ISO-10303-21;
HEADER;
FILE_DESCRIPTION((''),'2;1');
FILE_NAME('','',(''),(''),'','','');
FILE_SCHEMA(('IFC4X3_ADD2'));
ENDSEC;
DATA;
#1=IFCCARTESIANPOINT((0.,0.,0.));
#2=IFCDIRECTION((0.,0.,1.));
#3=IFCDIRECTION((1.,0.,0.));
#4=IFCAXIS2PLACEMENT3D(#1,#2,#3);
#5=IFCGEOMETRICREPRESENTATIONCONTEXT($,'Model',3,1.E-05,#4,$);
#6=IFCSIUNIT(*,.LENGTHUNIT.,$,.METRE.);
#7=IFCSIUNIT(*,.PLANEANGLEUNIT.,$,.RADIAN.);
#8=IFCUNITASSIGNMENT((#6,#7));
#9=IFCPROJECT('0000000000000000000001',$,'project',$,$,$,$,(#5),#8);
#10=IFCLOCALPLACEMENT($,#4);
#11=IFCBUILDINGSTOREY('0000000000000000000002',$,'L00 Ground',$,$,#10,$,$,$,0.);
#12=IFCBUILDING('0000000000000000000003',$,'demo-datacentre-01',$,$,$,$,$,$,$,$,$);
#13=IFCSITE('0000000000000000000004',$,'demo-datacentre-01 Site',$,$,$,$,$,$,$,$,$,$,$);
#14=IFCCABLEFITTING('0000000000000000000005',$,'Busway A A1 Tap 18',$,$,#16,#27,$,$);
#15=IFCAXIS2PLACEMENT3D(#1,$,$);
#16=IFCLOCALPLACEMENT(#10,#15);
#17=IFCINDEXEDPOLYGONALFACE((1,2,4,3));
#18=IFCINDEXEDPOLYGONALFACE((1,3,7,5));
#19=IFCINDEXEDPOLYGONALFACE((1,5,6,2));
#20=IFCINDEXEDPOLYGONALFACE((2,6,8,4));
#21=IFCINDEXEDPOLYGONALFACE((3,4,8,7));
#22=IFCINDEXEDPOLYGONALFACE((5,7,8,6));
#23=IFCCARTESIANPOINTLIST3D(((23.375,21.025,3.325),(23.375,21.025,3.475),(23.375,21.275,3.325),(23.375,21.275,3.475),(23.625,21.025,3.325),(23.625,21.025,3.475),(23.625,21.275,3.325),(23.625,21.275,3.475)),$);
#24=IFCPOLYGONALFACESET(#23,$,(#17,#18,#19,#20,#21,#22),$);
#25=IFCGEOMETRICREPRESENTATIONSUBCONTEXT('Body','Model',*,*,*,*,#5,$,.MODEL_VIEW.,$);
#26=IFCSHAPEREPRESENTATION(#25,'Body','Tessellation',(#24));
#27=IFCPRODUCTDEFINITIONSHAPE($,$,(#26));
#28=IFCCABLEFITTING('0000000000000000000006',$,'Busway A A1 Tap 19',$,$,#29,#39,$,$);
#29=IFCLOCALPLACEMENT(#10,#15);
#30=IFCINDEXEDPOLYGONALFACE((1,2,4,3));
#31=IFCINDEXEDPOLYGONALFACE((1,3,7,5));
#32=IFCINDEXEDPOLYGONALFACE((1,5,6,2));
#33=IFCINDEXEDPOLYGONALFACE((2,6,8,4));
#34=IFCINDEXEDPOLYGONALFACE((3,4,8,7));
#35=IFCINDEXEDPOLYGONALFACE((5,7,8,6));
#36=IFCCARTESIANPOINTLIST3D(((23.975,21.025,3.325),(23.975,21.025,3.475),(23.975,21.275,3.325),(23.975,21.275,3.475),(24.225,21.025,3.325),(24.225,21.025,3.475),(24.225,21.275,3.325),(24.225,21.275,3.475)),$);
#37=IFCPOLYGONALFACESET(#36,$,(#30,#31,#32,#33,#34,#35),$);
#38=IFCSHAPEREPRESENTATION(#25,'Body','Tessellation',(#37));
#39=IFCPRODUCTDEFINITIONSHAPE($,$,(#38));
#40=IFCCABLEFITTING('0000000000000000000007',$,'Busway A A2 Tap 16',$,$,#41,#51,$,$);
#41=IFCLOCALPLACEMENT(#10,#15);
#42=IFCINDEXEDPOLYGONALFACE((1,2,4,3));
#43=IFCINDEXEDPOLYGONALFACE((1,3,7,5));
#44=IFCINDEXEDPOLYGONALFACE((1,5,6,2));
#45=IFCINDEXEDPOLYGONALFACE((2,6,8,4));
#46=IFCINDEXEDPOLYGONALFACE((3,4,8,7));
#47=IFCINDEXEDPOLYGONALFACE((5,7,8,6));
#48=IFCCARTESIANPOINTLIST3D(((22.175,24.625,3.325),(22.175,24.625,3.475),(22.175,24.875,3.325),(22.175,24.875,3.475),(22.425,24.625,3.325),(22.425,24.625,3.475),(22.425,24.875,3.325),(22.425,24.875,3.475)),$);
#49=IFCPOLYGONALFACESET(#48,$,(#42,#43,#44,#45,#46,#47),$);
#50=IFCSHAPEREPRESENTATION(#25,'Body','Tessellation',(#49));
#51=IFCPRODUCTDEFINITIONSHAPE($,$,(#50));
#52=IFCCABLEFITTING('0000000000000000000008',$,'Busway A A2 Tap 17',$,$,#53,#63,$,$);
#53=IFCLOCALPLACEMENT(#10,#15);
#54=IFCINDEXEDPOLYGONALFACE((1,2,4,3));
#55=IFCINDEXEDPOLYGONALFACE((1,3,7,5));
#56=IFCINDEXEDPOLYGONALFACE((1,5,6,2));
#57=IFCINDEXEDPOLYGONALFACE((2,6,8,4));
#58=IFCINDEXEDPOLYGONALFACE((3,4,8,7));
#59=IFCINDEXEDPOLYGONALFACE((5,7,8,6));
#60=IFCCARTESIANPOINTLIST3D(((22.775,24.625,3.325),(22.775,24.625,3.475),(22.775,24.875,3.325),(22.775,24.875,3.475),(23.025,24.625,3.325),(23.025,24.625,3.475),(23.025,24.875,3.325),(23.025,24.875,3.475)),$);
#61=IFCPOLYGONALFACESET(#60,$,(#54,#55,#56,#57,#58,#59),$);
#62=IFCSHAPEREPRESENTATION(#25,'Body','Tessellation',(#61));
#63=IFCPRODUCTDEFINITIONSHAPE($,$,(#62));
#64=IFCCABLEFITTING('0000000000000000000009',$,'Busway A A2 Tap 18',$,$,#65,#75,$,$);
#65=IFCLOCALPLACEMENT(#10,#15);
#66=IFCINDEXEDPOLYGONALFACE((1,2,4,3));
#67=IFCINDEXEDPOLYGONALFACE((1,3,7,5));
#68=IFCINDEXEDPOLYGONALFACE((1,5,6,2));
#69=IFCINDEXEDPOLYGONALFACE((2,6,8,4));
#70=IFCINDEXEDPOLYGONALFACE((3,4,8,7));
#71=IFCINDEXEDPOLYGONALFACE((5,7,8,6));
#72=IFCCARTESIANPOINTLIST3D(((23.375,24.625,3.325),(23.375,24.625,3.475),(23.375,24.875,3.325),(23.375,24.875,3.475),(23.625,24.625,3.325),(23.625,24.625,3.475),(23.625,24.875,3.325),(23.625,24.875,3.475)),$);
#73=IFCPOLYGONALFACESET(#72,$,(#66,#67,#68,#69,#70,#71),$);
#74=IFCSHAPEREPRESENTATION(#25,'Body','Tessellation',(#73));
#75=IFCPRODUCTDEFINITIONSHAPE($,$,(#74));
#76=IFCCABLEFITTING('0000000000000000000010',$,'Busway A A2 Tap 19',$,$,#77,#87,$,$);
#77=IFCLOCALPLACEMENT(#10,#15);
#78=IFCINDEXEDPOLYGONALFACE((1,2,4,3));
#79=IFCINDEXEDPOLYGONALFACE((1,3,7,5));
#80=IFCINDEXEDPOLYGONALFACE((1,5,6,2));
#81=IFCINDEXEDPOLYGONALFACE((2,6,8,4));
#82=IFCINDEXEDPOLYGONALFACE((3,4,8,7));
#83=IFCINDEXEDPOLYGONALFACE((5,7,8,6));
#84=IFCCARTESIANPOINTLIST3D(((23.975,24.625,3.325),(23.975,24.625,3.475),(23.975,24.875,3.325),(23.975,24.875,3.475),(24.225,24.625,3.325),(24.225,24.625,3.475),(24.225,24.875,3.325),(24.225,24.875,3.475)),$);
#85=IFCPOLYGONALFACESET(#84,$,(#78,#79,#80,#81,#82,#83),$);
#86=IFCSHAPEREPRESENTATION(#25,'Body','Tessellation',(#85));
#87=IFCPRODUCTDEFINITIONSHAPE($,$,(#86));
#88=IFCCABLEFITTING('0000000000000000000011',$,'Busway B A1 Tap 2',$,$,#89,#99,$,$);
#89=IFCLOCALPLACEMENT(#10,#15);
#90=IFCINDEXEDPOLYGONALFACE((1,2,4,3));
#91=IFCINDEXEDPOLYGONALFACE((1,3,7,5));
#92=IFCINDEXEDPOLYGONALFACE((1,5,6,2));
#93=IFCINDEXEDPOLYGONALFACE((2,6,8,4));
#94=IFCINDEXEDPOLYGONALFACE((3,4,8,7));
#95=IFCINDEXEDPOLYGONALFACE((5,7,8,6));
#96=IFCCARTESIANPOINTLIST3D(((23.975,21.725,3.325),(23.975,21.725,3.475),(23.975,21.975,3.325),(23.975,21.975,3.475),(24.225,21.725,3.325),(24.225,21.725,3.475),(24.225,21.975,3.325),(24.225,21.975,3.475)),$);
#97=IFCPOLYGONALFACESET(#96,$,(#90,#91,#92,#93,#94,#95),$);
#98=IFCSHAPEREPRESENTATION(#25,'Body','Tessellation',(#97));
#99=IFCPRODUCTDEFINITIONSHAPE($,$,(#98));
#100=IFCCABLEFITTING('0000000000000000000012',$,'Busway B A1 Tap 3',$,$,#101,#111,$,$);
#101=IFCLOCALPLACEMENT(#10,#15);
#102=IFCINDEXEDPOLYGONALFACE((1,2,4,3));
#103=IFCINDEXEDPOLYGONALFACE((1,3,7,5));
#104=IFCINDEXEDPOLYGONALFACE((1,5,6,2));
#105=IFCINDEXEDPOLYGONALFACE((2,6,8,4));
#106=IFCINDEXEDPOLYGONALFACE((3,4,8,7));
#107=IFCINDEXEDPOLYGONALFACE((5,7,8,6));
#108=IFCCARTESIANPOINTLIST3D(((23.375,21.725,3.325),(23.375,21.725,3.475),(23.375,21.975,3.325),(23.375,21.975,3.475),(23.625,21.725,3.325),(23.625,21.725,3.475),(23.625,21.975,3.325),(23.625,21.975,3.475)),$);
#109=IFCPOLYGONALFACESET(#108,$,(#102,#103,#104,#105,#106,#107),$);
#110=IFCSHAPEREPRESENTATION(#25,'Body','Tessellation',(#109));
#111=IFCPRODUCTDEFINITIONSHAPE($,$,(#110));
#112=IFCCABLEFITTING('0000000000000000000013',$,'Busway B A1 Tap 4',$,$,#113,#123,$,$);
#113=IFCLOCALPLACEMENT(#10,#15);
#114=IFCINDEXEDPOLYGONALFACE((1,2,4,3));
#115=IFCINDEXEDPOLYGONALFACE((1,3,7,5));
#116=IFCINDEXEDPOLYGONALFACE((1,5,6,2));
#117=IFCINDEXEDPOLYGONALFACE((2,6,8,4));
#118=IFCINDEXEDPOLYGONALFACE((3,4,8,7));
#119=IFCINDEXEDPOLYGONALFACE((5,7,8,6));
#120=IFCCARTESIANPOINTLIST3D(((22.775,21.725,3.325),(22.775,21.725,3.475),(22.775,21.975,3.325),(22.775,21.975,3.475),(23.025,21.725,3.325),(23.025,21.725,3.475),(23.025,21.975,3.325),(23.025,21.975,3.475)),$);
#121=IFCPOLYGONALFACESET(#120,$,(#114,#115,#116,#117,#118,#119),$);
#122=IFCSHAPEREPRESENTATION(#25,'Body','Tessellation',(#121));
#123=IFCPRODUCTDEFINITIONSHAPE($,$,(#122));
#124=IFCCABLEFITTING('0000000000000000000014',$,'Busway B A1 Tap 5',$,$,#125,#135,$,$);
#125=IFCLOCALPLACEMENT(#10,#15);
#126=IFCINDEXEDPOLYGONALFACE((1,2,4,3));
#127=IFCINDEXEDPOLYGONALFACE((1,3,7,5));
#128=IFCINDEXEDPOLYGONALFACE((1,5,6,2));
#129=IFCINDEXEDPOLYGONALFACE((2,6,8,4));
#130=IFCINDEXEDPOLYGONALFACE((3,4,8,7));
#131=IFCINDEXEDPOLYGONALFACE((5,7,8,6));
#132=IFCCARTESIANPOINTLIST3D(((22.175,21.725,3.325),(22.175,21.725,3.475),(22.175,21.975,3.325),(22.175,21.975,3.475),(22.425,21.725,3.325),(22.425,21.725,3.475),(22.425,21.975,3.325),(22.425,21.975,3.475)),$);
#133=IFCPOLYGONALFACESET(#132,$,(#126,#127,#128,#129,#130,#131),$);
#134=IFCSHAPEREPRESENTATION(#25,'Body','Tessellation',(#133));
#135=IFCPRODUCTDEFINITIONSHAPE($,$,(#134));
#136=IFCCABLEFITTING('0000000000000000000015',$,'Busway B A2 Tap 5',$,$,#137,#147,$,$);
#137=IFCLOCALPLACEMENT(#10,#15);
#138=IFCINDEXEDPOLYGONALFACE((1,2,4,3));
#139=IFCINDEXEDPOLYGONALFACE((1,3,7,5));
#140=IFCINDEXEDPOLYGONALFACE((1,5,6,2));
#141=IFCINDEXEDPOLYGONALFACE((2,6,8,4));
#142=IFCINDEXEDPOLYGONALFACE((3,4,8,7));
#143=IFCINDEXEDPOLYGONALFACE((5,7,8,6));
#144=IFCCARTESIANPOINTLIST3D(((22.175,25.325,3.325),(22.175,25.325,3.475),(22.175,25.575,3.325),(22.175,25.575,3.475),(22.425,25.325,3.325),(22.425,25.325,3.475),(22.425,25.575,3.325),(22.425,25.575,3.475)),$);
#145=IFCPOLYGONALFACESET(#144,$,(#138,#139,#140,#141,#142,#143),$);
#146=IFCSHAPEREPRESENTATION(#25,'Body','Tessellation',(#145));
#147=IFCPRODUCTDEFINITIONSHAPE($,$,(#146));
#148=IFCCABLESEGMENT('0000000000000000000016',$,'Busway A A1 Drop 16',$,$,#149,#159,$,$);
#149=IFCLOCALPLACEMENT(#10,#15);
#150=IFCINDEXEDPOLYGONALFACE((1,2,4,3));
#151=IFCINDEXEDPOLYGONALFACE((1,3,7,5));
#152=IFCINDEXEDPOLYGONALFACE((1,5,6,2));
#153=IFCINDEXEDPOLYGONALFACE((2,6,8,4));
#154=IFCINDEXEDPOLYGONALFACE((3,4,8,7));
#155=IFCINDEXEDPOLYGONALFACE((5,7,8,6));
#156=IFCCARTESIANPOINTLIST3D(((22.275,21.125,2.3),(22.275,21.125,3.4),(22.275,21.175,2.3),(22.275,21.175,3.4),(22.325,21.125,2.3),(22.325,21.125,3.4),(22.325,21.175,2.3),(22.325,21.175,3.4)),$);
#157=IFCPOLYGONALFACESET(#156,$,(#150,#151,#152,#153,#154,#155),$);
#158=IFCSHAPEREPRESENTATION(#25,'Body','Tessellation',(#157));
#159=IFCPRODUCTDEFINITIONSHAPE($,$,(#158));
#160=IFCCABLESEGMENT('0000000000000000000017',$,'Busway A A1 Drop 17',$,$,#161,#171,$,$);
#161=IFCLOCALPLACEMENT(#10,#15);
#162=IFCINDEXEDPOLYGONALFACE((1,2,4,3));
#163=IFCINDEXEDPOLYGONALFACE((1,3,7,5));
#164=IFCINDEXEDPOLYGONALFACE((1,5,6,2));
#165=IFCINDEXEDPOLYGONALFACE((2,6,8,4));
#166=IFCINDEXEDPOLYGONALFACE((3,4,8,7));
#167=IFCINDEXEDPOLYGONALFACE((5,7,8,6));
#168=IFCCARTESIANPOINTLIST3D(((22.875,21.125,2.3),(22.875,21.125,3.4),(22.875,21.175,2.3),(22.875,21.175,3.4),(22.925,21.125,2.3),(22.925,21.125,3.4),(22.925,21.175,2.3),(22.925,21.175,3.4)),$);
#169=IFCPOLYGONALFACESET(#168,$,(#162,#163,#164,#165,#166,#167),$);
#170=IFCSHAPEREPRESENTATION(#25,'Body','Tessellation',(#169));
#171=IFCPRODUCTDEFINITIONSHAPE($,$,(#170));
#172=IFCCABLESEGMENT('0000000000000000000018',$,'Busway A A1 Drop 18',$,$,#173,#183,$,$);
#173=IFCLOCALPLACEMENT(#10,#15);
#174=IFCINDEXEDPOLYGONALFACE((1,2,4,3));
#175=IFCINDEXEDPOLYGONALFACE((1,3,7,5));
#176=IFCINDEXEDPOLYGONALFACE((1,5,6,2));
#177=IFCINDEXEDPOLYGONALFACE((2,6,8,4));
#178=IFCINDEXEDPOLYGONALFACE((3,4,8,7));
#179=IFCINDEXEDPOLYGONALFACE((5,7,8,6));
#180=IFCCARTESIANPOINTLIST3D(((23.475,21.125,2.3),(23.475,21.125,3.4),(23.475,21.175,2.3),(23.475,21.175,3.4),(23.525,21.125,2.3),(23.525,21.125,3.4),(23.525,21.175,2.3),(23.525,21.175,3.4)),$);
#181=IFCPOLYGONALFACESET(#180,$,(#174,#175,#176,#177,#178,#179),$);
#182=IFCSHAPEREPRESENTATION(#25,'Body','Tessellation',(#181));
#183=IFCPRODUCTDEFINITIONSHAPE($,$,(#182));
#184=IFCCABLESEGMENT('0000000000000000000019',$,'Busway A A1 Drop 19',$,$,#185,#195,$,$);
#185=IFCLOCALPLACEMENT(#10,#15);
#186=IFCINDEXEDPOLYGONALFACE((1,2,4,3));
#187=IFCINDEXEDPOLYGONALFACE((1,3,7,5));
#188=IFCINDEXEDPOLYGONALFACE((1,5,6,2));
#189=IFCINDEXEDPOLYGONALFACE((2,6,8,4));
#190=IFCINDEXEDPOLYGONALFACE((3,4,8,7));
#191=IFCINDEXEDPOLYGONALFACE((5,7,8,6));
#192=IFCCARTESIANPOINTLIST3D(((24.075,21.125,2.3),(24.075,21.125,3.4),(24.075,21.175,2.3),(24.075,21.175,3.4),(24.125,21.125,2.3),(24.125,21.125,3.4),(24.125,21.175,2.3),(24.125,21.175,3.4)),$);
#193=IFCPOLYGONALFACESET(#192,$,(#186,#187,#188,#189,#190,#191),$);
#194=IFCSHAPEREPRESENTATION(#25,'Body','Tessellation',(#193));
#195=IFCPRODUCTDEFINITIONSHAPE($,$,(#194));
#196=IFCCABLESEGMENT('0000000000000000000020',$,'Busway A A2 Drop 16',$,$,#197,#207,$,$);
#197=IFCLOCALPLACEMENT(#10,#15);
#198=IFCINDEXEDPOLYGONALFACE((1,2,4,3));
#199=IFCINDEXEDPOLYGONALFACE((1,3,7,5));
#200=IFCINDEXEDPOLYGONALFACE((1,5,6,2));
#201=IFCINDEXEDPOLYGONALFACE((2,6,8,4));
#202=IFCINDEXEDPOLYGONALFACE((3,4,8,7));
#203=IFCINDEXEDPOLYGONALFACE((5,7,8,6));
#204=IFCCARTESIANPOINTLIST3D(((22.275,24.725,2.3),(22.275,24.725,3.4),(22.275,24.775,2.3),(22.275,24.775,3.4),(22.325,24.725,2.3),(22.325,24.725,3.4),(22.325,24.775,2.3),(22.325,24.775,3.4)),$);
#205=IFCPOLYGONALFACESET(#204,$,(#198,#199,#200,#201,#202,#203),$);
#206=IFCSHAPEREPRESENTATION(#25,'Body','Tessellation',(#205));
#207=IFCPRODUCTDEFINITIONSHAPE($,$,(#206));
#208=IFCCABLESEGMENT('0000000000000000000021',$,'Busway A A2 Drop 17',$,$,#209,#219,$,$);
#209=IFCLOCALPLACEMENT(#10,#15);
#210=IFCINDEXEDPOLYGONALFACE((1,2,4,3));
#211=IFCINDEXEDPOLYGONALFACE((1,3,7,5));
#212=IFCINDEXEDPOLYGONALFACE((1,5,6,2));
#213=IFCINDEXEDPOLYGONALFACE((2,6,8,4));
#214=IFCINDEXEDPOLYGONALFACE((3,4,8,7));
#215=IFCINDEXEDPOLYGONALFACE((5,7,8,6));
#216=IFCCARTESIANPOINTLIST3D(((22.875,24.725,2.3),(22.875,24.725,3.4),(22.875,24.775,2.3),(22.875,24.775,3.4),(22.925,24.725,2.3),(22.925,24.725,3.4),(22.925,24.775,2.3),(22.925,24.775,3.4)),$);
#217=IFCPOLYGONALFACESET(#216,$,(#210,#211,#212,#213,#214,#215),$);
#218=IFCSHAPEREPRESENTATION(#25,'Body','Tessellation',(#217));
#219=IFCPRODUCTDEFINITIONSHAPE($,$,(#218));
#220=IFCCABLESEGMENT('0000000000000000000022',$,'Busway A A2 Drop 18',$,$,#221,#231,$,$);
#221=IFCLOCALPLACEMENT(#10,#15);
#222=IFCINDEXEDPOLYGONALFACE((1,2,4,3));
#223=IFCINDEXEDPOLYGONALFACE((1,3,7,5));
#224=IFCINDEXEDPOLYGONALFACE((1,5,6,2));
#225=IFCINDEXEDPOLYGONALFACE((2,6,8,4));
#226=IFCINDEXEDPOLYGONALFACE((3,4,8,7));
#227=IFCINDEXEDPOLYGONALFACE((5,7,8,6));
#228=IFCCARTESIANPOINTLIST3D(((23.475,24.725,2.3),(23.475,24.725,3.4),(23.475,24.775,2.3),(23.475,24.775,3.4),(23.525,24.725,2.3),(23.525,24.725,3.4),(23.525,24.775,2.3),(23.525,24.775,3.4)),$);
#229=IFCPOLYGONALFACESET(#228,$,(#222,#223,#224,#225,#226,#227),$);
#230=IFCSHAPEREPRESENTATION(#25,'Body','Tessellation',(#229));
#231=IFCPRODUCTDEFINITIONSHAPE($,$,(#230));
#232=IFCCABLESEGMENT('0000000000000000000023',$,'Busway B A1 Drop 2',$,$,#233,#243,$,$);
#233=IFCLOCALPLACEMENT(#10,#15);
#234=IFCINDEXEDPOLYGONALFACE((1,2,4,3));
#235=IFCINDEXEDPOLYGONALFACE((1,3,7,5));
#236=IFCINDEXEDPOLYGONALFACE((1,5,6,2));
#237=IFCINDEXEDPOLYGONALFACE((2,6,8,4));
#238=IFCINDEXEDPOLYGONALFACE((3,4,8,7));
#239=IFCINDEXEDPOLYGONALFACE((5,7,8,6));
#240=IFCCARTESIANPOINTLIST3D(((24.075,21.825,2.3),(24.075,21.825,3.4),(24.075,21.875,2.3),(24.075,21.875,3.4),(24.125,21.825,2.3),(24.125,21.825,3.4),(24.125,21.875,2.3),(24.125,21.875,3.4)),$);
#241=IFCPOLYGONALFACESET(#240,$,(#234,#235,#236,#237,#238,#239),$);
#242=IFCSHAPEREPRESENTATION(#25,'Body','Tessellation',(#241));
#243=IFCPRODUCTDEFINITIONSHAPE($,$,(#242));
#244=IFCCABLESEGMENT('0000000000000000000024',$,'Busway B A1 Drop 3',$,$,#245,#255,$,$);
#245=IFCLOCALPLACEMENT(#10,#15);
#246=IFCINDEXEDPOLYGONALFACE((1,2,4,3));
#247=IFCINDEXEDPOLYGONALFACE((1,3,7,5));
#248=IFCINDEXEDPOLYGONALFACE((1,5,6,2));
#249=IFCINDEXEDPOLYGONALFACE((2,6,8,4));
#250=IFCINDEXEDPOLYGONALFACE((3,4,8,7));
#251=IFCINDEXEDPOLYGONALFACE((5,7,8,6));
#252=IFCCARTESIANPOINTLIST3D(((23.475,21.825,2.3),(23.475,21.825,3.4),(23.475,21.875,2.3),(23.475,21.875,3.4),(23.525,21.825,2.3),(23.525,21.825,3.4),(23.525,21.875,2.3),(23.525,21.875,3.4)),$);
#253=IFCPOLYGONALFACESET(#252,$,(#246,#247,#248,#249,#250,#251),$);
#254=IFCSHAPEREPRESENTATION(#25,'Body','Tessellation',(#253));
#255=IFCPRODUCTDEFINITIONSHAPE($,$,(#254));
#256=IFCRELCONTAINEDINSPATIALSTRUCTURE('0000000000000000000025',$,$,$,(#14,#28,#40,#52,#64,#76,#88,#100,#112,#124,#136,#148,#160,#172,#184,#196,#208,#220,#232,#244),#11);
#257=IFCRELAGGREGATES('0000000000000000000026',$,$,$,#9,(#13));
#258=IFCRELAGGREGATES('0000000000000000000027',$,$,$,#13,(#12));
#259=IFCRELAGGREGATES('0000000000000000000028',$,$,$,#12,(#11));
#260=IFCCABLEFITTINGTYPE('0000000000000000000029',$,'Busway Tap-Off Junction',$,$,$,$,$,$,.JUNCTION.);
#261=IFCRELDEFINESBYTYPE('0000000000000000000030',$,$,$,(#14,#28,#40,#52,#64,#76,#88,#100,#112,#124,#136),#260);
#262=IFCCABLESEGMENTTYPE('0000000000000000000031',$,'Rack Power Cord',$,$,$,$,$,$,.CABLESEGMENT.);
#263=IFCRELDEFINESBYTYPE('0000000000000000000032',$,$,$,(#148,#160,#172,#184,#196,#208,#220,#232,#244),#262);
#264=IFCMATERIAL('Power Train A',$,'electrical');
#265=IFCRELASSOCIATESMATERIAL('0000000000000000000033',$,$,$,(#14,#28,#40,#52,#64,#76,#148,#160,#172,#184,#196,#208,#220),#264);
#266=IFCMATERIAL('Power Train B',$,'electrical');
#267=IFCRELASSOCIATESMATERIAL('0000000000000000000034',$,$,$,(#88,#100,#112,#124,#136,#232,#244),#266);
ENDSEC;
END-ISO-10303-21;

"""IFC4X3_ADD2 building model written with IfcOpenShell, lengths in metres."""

from ifc_helpers import new_model, si_unit, frame, origin_with_axes, place, context, subcontext, project, spatial, rectangle, extrude, material, type_object, element, save


model = new_model("IFC4X3_ADD2")

# Units and contexts
model_context = context("Model", 3, precision=1e-05, world=origin_with_axes())
body_context = subcontext(model_context, "Body", "Model", "MODEL_VIEW")
ifc_project = project(units=[si_unit("LENGTHUNIT", "METRE"), si_unit("PLANEANGLEUNIT", "RADIAN")], contexts=[model_context])

# Site, building, storey
site = spatial("IfcSite", under=ifc_project, Name="demo-datacentre-01 Site")
building = spatial("IfcBuilding", under=site, Name="demo-datacentre-01")
storey_placement = place(None, origin_with_axes())
storey = spatial("IfcBuildingStorey", under=building, at=storey_placement, Name="L00 Ground", Elevation=0.0)

# Shared definitions
ifc_material_1 = material(Name="Power Train B", Category="electrical")

# Shared definitions
ifc_material_2 = material(Name="Power Train A", Category="electrical")

# Cable fittings
cable_fitting_type_1 = type_object("IfcCableFittingType", Name="Busway Tap-Off Junction", PredefinedType="JUNCTION")
for number, where, z_axis, x_axis, name in (
    (1, (23.5, 21.15, 3.325), (0.0, 0.0, 1.0), (1.0, 0.0, 0.0), "Busway A A1 Tap 18"),
    (2, (24.1, 21.15, 3.325), (0.0, 0.0, 1.0), (1.0, 0.0, 0.0), "Busway A A1 Tap 19"),
    (3, (22.3, 24.75, 3.325), (0.0, 0.0, 1.0), (1.0, 0.0, 0.0), "Busway A A2 Tap 16"),
    (4, (22.9, 24.75, 3.325), (0.0, 0.0, 1.0), (1.0, 0.0, 0.0), "Busway A A2 Tap 17"),
    (5, (23.5, 24.75, 3.325), (0.0, 0.0, 1.0), (1.0, 0.0, 0.0), "Busway A A2 Tap 18"),
    (6, (24.1, 24.75, 3.325), (0.0, 0.0, 1.0), (1.0, 0.0, 0.0), "Busway A A2 Tap 19"),
):
    element("IfcCableFitting", number, at=place(storey_placement, frame(where, z_axis=z_axis, x_axis=x_axis)), inside=storey, type_object=cable_fitting_type_1, material=ifc_material_2, Name=name, context=body_context, shape_type="SweptSolid", body=[
        extrude(rectangle(XDim=0.25, YDim=0.25), origin_with_axes(), (0.0, 0.0, 1.0), 0.15),
    ])
for number, where, z_axis, x_axis, name in (
    (7, (24.1, 21.85, 3.325), (0.0, 0.0, 1.0), (1.0, 0.0, 0.0), "Busway B A1 Tap 2"),
    (8, (23.5, 21.85, 3.325), (0.0, 0.0, 1.0), (1.0, 0.0, 0.0), "Busway B A1 Tap 3"),
    (9, (22.9, 21.85, 3.325), (0.0, 0.0, 1.0), (1.0, 0.0, 0.0), "Busway B A1 Tap 4"),
    (10, (22.3, 21.85, 3.325), (0.0, 0.0, 1.0), (1.0, 0.0, 0.0), "Busway B A1 Tap 5"),
    (11, (22.3, 25.45, 3.325), (0.0, 0.0, 1.0), (1.0, 0.0, 0.0), "Busway B A2 Tap 5"),
):
    element("IfcCableFitting", number, at=place(storey_placement, frame(where, z_axis=z_axis, x_axis=x_axis)), inside=storey, type_object=cable_fitting_type_1, material=ifc_material_1, Name=name, context=body_context, shape_type="SweptSolid", body=[
        extrude(rectangle(XDim=0.25, YDim=0.25), origin_with_axes(), (0.0, 0.0, 1.0), 0.15),
    ])

# Cable segments
cable_segment_type_1 = type_object("IfcCableSegmentType", Name="Rack Power Cord", PredefinedType="CABLESEGMENT")
for number, where, z_axis, x_axis, name in (
    (12, (22.3, 21.15, 3.4), (0.0, 0.0, -1.0), (1.0, 0.0, 0.0), "Busway A A1 Drop 16"),
    (13, (22.9, 21.15, 3.4), (0.0, 0.0, -1.0), (1.0, 0.0, 0.0), "Busway A A1 Drop 17"),
    (14, (23.5, 21.15, 3.4), (0.0, 0.0, -1.0), (1.0, 0.0, 0.0), "Busway A A1 Drop 18"),
    (15, (24.1, 21.15, 3.4), (0.0, 0.0, -1.0), (1.0, 0.0, 0.0), "Busway A A1 Drop 19"),
    (16, (22.3, 24.75, 3.4), (0.0, 0.0, -1.0), (1.0, 0.0, 0.0), "Busway A A2 Drop 16"),
    (17, (22.9, 24.75, 3.4), (0.0, 0.0, -1.0), (1.0, 0.0, 0.0), "Busway A A2 Drop 17"),
    (18, (23.5, 24.75, 3.4), (0.0, 0.0, -1.0), (1.0, 0.0, 0.0), "Busway A A2 Drop 18"),
):
    element("IfcCableSegment", number, at=place(storey_placement, frame(where, z_axis=z_axis, x_axis=x_axis)), inside=storey, type_object=cable_segment_type_1, material=ifc_material_2, Name=name, context=body_context, shape_type="SweptSolid", body=[
        extrude(rectangle(XDim=0.05, YDim=0.05), origin_with_axes(), (0.0, 0.0, 1.0), 1.1),
    ])
for number, where, z_axis, x_axis, name in (
    (19, (24.1, 21.85, 3.4), (0.0, 0.0, -1.0), (1.0, 0.0, 0.0), "Busway B A1 Drop 2"),
    (20, (23.5, 21.85, 3.4), (0.0, 0.0, -1.0), (1.0, 0.0, 0.0), "Busway B A1 Drop 3"),
):
    element("IfcCableSegment", number, at=place(storey_placement, frame(where, z_axis=z_axis, x_axis=x_axis)), inside=storey, type_object=cable_segment_type_1, material=ifc_material_1, Name=name, context=body_context, shape_type="SweptSolid", body=[
        extrude(rectangle(XDim=0.05, YDim=0.05), origin_with_axes(), (0.0, 0.0, 1.0), 1.1),
    ])

save(model, "model.ifc")
